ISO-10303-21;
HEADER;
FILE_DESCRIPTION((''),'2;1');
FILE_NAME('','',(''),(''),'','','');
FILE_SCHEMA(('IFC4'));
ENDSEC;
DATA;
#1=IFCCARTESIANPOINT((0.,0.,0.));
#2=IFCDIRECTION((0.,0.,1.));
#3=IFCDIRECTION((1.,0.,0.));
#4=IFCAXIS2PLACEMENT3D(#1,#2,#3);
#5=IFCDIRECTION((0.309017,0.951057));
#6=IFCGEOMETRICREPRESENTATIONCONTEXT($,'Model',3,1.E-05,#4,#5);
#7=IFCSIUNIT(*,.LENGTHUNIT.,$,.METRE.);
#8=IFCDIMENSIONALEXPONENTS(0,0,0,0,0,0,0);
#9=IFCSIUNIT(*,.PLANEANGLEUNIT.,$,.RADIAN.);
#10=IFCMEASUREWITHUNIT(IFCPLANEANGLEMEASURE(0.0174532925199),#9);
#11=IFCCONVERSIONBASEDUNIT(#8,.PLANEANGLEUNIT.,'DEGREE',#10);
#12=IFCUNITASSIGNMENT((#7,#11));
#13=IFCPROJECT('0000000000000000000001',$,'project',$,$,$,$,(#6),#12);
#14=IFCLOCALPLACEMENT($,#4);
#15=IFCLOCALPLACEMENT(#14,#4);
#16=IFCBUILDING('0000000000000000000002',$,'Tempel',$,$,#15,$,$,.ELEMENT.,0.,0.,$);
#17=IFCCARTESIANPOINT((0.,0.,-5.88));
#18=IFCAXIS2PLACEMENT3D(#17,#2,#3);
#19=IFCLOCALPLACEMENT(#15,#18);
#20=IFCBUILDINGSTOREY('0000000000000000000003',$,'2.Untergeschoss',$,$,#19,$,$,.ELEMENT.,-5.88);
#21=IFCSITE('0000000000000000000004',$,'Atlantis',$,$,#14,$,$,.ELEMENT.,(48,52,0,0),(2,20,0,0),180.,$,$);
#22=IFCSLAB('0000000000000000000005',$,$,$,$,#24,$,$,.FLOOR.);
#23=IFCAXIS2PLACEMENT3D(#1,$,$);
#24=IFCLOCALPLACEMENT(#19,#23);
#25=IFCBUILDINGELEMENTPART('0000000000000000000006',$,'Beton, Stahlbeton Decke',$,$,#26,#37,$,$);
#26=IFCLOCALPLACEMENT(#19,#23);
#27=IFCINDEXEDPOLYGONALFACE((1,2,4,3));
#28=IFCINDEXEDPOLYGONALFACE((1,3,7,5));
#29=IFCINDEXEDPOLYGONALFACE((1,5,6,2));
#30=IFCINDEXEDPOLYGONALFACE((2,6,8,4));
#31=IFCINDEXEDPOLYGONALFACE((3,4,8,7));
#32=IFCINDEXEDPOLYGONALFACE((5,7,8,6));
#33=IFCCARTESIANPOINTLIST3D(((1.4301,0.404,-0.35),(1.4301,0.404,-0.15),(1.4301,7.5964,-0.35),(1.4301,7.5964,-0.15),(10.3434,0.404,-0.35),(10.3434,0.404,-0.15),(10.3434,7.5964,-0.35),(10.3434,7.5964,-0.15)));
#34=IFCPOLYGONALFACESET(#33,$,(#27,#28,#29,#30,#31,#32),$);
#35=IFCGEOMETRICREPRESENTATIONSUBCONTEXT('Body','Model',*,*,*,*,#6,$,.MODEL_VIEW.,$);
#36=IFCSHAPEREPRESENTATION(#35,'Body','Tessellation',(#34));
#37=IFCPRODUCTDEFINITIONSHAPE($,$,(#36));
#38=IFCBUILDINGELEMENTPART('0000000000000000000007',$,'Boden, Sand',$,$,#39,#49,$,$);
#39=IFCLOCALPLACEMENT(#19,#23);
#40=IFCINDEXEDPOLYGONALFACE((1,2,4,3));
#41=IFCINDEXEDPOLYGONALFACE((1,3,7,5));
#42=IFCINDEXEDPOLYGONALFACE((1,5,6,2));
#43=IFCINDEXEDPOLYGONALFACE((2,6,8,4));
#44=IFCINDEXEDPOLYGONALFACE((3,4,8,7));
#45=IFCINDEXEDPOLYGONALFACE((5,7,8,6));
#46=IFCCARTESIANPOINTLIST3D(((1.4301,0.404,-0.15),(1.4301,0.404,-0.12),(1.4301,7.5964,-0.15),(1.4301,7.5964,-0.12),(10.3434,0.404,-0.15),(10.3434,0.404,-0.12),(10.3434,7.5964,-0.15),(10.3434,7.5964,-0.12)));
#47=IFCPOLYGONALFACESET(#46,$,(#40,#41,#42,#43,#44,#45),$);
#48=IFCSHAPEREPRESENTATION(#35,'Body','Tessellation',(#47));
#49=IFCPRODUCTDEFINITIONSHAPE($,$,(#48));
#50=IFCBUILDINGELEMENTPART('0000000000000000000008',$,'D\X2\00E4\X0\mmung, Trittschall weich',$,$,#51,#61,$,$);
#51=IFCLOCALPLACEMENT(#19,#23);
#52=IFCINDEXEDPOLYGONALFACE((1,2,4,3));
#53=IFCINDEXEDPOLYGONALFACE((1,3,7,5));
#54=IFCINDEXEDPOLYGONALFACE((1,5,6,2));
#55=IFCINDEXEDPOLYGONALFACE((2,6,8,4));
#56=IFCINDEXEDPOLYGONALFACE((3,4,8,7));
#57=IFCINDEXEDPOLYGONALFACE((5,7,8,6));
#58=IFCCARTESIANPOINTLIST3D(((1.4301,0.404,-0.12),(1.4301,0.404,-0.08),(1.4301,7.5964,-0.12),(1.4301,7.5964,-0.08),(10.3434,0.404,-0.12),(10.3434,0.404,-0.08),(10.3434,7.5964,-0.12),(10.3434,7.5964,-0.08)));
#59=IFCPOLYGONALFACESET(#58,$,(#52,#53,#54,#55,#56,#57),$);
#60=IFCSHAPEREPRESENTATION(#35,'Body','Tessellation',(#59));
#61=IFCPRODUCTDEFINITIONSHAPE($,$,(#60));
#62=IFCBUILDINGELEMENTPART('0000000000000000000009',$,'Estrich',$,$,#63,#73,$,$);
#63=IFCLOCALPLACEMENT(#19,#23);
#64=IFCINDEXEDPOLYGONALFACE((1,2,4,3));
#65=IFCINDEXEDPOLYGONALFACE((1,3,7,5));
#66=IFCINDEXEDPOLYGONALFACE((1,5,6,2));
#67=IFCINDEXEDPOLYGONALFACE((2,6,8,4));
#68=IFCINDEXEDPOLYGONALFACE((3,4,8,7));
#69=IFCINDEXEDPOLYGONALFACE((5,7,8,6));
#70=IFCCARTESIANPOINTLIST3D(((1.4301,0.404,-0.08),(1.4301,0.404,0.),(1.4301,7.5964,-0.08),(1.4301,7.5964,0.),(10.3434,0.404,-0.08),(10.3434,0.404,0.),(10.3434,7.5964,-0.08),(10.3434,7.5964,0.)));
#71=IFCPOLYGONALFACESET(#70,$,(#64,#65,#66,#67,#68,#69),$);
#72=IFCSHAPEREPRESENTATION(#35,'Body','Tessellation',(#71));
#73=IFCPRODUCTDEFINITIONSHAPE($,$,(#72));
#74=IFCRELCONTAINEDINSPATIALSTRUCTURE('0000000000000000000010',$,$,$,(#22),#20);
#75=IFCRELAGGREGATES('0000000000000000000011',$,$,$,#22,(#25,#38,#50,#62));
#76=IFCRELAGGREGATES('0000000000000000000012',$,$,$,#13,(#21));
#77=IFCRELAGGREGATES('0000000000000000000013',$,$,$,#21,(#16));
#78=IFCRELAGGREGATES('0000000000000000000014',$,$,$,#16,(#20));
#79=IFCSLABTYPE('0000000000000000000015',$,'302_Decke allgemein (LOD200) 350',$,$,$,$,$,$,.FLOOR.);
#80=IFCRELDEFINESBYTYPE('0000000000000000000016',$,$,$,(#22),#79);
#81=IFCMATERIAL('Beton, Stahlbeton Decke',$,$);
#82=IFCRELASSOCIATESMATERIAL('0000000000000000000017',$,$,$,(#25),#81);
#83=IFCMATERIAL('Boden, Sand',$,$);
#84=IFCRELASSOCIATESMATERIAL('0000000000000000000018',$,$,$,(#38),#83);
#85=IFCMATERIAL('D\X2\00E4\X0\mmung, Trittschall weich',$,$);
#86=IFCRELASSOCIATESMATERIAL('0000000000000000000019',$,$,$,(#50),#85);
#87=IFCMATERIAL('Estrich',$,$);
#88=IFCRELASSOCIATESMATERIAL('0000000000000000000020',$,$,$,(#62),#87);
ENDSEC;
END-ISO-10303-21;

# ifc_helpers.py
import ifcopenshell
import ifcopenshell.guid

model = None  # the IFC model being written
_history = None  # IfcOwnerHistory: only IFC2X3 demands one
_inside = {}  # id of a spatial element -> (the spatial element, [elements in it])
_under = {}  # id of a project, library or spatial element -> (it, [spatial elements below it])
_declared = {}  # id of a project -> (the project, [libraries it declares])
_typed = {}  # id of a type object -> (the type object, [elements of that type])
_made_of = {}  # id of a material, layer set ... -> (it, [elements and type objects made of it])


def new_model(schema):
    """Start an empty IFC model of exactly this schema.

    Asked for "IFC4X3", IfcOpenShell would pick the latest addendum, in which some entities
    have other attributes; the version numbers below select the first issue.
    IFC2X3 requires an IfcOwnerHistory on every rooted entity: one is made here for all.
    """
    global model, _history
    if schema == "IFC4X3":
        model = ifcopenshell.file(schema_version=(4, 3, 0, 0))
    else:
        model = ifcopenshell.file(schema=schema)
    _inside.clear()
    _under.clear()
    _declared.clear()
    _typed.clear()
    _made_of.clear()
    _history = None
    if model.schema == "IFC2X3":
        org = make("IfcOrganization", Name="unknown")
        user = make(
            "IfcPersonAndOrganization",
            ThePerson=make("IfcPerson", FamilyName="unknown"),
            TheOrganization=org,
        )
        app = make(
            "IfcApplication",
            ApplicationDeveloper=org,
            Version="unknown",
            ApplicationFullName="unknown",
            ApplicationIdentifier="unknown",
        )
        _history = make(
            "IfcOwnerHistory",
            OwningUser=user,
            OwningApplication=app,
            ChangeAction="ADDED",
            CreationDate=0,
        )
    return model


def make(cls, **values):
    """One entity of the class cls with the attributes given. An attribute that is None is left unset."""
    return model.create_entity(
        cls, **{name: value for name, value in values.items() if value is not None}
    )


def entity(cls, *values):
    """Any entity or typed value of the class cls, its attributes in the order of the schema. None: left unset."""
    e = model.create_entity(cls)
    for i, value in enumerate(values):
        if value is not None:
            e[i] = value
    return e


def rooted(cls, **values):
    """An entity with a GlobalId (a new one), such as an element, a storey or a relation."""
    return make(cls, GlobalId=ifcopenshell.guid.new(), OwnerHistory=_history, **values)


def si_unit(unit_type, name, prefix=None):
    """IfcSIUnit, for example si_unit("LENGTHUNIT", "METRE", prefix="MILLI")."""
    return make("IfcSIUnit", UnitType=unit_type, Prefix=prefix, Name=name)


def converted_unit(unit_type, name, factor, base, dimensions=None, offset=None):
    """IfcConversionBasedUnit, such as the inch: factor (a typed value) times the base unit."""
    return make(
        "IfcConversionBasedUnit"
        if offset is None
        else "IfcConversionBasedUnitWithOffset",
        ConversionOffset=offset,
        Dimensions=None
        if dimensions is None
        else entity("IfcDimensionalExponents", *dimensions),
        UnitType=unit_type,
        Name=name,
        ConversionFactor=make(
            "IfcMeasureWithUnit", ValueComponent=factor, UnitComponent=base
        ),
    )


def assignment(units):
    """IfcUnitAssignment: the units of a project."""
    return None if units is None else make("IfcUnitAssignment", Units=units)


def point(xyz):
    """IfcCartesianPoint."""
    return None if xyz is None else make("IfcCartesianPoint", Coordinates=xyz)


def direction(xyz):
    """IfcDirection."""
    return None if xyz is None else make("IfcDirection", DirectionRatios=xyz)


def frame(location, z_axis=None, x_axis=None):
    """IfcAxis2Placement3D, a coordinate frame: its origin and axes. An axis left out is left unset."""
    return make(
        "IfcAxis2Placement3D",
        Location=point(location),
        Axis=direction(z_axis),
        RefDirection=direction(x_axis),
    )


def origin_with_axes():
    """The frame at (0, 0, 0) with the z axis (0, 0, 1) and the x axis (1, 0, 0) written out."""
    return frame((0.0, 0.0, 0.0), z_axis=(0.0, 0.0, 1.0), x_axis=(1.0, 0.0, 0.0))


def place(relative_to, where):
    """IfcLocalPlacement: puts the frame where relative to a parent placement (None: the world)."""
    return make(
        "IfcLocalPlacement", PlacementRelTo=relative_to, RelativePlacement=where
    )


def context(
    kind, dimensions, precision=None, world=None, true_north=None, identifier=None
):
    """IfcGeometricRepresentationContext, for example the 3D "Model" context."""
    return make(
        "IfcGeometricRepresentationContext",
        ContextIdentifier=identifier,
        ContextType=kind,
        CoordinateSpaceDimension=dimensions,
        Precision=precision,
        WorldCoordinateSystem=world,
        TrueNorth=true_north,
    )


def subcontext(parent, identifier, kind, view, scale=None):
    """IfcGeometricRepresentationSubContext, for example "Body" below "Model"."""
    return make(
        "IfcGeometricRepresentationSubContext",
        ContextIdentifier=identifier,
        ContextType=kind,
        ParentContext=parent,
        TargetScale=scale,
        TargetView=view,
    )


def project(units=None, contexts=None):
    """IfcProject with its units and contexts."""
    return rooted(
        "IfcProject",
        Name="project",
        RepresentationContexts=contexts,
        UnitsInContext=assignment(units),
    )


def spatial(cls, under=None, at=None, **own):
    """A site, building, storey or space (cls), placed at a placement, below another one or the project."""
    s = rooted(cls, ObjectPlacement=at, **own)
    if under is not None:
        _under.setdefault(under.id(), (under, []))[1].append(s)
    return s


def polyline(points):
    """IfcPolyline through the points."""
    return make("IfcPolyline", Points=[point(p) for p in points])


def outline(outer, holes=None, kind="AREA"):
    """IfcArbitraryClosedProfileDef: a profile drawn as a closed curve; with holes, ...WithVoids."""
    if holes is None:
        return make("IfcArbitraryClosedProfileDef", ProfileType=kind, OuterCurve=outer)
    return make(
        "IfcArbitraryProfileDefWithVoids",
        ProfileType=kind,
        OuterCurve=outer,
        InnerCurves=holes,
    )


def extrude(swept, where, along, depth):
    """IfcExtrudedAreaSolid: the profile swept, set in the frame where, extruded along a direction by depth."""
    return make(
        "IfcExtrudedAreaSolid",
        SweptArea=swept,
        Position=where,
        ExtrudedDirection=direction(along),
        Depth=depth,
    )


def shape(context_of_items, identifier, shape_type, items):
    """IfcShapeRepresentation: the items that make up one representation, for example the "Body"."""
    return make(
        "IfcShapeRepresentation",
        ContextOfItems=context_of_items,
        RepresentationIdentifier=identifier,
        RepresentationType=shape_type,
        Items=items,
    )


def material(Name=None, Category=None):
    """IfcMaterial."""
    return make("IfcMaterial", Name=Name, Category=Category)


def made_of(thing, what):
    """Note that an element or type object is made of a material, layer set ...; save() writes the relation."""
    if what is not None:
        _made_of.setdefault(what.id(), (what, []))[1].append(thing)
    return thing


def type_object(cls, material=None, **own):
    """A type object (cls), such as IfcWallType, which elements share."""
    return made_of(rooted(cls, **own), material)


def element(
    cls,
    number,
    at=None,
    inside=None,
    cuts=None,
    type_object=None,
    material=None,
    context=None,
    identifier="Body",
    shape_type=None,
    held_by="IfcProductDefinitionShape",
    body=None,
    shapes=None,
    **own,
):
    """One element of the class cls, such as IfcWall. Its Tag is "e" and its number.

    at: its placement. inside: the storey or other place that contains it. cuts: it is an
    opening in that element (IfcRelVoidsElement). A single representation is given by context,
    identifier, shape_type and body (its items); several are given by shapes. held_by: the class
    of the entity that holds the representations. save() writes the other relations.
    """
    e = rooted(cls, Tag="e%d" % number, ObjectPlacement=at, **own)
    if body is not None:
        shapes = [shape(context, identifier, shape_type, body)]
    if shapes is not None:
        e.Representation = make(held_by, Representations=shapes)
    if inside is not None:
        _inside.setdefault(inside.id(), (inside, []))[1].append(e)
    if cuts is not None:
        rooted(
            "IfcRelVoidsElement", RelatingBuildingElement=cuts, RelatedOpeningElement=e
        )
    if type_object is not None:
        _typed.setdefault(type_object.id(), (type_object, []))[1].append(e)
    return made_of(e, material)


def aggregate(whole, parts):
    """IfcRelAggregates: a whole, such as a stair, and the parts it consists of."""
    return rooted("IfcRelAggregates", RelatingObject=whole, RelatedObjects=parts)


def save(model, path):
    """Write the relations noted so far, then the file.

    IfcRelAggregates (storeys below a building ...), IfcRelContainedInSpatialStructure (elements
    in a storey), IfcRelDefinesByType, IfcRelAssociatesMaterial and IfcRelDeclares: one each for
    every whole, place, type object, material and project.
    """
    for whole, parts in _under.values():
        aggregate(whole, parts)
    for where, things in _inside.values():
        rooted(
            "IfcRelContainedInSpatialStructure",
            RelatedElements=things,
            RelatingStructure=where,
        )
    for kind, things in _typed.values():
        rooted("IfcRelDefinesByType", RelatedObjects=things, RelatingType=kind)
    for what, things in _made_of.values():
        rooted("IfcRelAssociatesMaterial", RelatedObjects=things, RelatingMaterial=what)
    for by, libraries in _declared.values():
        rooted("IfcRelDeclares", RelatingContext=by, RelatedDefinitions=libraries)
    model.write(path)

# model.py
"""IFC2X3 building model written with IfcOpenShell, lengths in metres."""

from ifc_helpers import new_model, entity, si_unit, converted_unit, direction, frame, origin_with_axes, place, context, subcontext, project, spatial, polyline, outline, extrude, material, type_object, element, aggregate, save


model = new_model("IFC2X3")

# Units and contexts
model_context = context("Model", 3, precision=1e-05, world=origin_with_axes(), true_north=direction((0.309017, 0.951057)))
body_context = subcontext(model_context, "Body", "Model", "MODEL_VIEW")
ifc_project = project(units=[si_unit("LENGTHUNIT", "METRE"), converted_unit("PLANEANGLEUNIT", "DEGREE", entity("IfcPlaneAngleMeasure", 0.0174532925199), si_unit("PLANEANGLEUNIT", "RADIAN"), dimensions=[0, 0, 0, 0, 0, 0, 0])], contexts=[model_context])

# Site, building, storey
site_placement = place(None, origin_with_axes())
site = spatial("IfcSite", under=ifc_project, at=site_placement, Name="Atlantis", CompositionType="ELEMENT", RefLatitude=(48, 52, 0, 0), RefLongitude=(2, 20, 0, 0), RefElevation=180.0)
building_placement = place(site_placement, origin_with_axes())
building = spatial("IfcBuilding", under=site, at=building_placement, Name="Tempel", CompositionType="ELEMENT", ElevationOfRefHeight=0.0, ElevationOfTerrain=0.0)
storey_placement = place(building_placement, frame((0.0, 0.0, -5.88), z_axis=(0.0, 0.0, 1.0), x_axis=(1.0, 0.0, 0.0)))
storey = spatial("IfcBuildingStorey", under=building, at=storey_placement, Name="2.Untergeschoss", CompositionType="ELEMENT", Elevation=-5.88)

# Slab, building element parts
slab_type = type_object("IfcSlabType", Name="302_Decke allgemein (LOD200) 350", PredefinedType="FLOOR")
slab_placement = place(storey_placement, frame((1.4301, 0.404, -0.15), z_axis=(0.0, 0.0, 1.0), x_axis=(1.0, 0.0, 0.0)))
slab = element("IfcSlab", 1, at=slab_placement, inside=storey, type_object=slab_type, PredefinedType="FLOOR")
ifc_material_1 = material(Name="Beton, Stahlbeton Decke")
building_element_part_1_placement = place(slab_placement, origin_with_axes())
building_element_part_1 = element("IfcBuildingElementPart", 2, at=building_element_part_1_placement, material=ifc_material_1, Name="Beton, Stahlbeton Decke", context=body_context, shape_type="SweptSolid", body=[
    extrude(outline(polyline([(0.0, 0.0), (8.9133, 0.0), (8.9133, 7.1924), (0.0, 7.1924), (0.0, 0.0)])), frame((0.0, 0.0, -0.2), z_axis=(0.0, 0.0, 1.0), x_axis=(1.0, 0.0, 0.0)), (0.0, 0.0, 1.0), 0.2),
])
ifc_material_2 = material(Name="Boden, Sand")
building_element_part_2_placement = place(slab_placement, origin_with_axes())
building_element_part_2 = element("IfcBuildingElementPart", 3, at=building_element_part_2_placement, material=ifc_material_2, Name="Boden, Sand", context=body_context, shape_type="SweptSolid", body=[
    extrude(outline(polyline([(0.0, 0.0), (8.9133, 0.0), (8.9133, 7.1924), (0.0, 7.1924), (0.0, 0.0)])), origin_with_axes(), (0.0, 0.0, 1.0), 0.03),
])
ifc_material_3 = material(Name="Dämmung, Trittschall weich")
building_element_part_3_placement = place(slab_placement, origin_with_axes())
building_element_part_3 = element("IfcBuildingElementPart", 4, at=building_element_part_3_placement, material=ifc_material_3, Name="Dämmung, Trittschall weich", context=body_context, shape_type="SweptSolid", body=[
    extrude(outline(polyline([(0.0, 0.0), (8.9133, 0.0), (8.9133, 7.1924), (0.0, 7.1924), (0.0, 0.0)])), frame((0.0, 0.0, 0.03), z_axis=(0.0, 0.0, 1.0), x_axis=(1.0, 0.0, 0.0)), (0.0, 0.0, 1.0), 0.04),
])
ifc_material_4 = material(Name="Estrich")
building_element_part_4_placement = place(slab_placement, origin_with_axes())
building_element_part_4 = element("IfcBuildingElementPart", 5, at=building_element_part_4_placement, material=ifc_material_4, Name="Estrich", context=body_context, shape_type="SweptSolid", body=[
    extrude(outline(polyline([(0.0, 0.0), (8.9133, 0.0), (8.9133, 7.1924), (0.0, 7.1924), (0.0, 0.0)])), frame((0.0, 0.0, 0.07), z_axis=(0.0, 0.0, 1.0), x_axis=(1.0, 0.0, 0.0)), (0.0, 0.0, 1.0), 0.08),
])
aggregate(slab, [building_element_part_1, building_element_part_2, building_element_part_3, building_element_part_4])

save(model, "model.ifc")
